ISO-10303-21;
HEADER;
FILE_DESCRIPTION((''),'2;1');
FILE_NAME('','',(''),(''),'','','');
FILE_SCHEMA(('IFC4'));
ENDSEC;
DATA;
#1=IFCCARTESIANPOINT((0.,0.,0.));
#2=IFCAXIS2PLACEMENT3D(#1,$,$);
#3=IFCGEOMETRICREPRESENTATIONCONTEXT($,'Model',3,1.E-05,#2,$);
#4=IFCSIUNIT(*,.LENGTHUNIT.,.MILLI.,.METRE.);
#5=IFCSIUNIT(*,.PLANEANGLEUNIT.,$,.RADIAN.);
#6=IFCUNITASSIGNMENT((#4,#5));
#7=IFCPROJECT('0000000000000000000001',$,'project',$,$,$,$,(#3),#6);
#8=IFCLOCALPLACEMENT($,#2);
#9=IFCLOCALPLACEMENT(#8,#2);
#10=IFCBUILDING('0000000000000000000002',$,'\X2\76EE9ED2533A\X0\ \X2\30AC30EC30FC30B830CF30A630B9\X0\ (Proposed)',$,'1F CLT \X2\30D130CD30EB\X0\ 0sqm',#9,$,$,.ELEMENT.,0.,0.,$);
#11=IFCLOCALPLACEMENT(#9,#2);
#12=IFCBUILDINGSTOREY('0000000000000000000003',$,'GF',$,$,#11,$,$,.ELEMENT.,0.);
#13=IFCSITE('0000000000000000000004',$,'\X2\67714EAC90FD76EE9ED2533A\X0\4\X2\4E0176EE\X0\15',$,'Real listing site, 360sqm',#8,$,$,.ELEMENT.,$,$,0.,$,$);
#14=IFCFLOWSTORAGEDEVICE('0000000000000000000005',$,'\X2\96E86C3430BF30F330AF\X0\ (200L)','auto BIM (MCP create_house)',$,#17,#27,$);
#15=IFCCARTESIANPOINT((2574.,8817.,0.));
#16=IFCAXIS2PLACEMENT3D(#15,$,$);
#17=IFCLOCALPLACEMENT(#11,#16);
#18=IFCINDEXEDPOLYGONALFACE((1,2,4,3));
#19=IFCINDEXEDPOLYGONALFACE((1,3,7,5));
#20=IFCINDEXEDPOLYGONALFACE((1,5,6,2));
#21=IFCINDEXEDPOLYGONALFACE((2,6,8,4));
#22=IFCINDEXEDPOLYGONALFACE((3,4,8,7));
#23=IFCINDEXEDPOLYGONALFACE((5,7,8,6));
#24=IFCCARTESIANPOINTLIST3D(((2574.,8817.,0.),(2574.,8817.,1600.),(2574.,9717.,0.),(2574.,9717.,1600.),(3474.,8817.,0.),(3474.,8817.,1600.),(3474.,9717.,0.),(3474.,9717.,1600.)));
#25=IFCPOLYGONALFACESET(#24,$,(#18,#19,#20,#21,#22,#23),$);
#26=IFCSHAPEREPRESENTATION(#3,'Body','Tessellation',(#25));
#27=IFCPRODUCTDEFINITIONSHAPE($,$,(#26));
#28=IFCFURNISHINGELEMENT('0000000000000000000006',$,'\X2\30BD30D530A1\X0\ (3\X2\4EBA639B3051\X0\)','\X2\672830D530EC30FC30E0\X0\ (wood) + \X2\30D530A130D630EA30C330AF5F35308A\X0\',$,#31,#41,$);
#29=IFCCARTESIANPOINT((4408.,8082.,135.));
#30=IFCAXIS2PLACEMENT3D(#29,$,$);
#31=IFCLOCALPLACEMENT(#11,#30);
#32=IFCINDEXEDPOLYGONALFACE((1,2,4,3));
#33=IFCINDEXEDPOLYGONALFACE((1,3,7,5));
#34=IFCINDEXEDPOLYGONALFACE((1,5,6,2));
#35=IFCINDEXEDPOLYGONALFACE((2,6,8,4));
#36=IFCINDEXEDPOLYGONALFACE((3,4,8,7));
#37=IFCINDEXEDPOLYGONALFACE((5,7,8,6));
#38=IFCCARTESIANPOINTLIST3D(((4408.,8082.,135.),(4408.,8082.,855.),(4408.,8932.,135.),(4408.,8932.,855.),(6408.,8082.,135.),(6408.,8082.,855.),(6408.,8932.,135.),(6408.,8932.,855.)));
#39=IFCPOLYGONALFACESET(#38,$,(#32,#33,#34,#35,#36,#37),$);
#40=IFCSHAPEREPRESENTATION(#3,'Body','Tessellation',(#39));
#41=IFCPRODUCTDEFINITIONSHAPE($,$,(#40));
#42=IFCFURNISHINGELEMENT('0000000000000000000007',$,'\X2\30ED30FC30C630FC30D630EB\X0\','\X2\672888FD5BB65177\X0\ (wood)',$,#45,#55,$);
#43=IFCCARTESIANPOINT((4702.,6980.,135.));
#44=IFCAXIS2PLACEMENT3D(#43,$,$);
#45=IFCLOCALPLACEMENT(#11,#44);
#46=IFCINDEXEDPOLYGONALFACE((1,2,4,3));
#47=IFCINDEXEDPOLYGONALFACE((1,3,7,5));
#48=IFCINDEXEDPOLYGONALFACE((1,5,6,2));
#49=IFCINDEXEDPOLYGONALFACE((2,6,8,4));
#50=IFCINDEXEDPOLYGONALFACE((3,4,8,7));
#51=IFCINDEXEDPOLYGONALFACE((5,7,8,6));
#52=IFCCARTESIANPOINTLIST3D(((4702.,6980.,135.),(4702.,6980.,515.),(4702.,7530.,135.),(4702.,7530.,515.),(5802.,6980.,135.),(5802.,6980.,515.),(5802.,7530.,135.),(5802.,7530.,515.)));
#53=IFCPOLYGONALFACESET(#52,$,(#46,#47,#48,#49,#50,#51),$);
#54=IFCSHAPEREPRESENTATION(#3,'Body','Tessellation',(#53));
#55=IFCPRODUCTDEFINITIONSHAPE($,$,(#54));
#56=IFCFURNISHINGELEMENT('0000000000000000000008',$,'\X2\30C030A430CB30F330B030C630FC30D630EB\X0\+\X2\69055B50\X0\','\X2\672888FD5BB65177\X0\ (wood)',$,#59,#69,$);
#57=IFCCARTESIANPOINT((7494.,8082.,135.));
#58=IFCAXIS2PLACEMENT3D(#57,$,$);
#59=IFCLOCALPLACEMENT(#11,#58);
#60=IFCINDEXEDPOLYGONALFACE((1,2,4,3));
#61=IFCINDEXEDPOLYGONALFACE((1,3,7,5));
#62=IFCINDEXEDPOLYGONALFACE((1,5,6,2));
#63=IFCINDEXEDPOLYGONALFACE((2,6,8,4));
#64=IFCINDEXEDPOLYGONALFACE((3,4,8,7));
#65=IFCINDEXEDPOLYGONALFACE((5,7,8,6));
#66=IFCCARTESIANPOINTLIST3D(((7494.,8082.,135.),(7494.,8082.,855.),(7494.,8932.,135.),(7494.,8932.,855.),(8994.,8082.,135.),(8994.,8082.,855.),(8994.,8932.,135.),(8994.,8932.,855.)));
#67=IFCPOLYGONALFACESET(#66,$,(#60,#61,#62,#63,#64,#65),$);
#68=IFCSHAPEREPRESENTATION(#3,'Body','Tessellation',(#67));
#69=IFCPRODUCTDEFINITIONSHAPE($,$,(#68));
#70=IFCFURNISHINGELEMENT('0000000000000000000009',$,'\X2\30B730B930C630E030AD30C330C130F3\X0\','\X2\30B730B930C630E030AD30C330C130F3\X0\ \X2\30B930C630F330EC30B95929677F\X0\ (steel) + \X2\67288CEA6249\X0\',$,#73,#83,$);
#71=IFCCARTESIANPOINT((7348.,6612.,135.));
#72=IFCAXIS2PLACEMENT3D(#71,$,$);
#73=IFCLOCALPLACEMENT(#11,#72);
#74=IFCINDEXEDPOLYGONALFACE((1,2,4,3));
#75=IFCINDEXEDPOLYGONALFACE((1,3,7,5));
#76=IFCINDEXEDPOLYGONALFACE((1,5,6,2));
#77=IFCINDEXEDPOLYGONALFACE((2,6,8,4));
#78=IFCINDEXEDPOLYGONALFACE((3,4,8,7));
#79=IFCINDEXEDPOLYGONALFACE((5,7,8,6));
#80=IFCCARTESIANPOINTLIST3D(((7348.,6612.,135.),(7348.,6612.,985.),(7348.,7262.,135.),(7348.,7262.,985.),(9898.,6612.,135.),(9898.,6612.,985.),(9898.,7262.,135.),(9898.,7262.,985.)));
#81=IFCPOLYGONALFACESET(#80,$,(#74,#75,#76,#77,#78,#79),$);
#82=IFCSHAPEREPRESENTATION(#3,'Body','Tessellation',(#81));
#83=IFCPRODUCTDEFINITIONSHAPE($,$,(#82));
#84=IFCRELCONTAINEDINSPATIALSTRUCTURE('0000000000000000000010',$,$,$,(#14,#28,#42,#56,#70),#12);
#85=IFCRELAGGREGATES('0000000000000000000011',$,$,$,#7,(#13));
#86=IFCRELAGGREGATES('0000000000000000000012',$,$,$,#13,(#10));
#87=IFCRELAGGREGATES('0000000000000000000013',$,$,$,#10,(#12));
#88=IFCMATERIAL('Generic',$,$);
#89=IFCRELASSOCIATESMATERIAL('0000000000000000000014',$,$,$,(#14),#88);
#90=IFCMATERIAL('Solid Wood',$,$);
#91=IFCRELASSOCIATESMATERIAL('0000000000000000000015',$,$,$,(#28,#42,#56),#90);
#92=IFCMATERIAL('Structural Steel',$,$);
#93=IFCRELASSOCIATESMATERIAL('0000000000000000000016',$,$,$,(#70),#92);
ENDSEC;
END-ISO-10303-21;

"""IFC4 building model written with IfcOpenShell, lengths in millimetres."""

from ifc_helpers import new_model, si_unit, frame, frame_2d, origin, place, context, project, spatial, rectangle, extrude, material, element, save


model = new_model("IFC4")

# Units and contexts
model_context = context("Model", 3, precision=1e-05, world=origin())
ifc_project = project(units=[si_unit("LENGTHUNIT", "METRE", prefix="MILLI"), si_unit("PLANEANGLEUNIT", "RADIAN")], contexts=[model_context])

# Site, building, storey
site_placement = place(None, origin())
site = spatial("IfcSite", under=ifc_project, at=site_placement, Name="東京都目黒区4丁目15", ObjectType="Real listing site, 360sqm", CompositionType="ELEMENT", RefElevation=0.0)
building_placement = place(site_placement, origin())
building = spatial("IfcBuilding", under=site, at=building_placement, Name="目黒区 ガレージハウス (Proposed)", ObjectType="1F CLT パネル 0sqm", CompositionType="ELEMENT", ElevationOfRefHeight=0.0, ElevationOfTerrain=0.0)
storey_placement = place(building_placement, origin())
storey = spatial("IfcBuildingStorey", under=building, at=storey_placement, Name="GF", CompositionType="ELEMENT", Elevation=0.0)

# Shared definitions
ifc_material_1 = material(Name="Solid Wood")

# Shared definitions
ifc_material_2 = material(Name="Structural Steel")

# Shared definitions
ifc_material_3 = material(Name="Generic")

# Flow storage device
flow_storage_device_placement = place(storey_placement, frame((2574.0, 8817.0, 0.0)))
element("IfcFlowStorageDevice", 1, at=flow_storage_device_placement, inside=storey, material=ifc_material_3, Name="雨水タンク (200L)", Description="auto BIM (MCP create_house)", context=model_context, shape_type="SweptSolid", body=[
    extrude(rectangle(XDim=900.0, YDim=900.0, at=frame_2d((450.0, 450.0))), frame((2574.0, 8817.0, 0.0)), (0.0, 0.0, 1.0), 1600.0),
])

# Furnishing elements
furnishing_1_placement = place(storey_placement, frame((4408.0, 8082.0, 135.0)))
element("IfcFurnishingElement", 2, at=furnishing_1_placement, inside=storey, material=ifc_material_1, Name="ソファ (3人掛け)", Description="木フレーム (wood) + ファブリック張り", context=model_context, shape_type="SweptSolid", body=[
    extrude(rectangle(XDim=2000.0, YDim=850.0, at=frame_2d((1000.0, 425.0))), frame((4408.0, 8082.0, 135.0)), (0.0, 0.0, 1.0), 720.0),
])
furnishing_2_placement = place(storey_placement, frame((4702.0, 6980.0, 135.0)))
element("IfcFurnishingElement", 3, at=furnishing_2_placement, inside=storey, material=ifc_material_1, Name="ローテーブル", Description="木製家具 (wood)", context=model_context, shape_type="SweptSolid", body=[
    extrude(rectangle(XDim=1100.0, YDim=550.0, at=frame_2d((550.0, 275.0))), frame((4702.0, 6980.0, 135.0)), (0.0, 0.0, 1.0), 380.0),
])
furnishing_3_placement = place(storey_placement, frame((7494.0, 8082.0, 135.0)))
element("IfcFurnishingElement", 4, at=furnishing_3_placement, inside=storey, material=ifc_material_1, Name="ダイニングテーブル+椅子", Description="木製家具 (wood)", context=model_context, shape_type="SweptSolid", body=[
    extrude(rectangle(XDim=1500.0, YDim=850.0, at=frame_2d((750.0, 425.0))), frame((7494.0, 8082.0, 135.0)), (0.0, 0.0, 1.0), 720.0),
])
furnishing_4_placement = place(storey_placement, frame((7348.0, 6612.0, 135.0)))
element("IfcFurnishingElement", 5, at=furnishing_4_placement, inside=storey, material=ifc_material_2, Name="システムキッチン", Description="システムキッチン ステンレス天板 (steel) + 木質扉", context=model_context, shape_type="SweptSolid", body=[
    extrude(rectangle(XDim=2550.0, YDim=650.0, at=frame_2d((1275.0, 325.0))), frame((7348.0, 6612.0, 135.0)), (0.0, 0.0, 1.0), 850.0),
])

save(model, "model.ifc")
